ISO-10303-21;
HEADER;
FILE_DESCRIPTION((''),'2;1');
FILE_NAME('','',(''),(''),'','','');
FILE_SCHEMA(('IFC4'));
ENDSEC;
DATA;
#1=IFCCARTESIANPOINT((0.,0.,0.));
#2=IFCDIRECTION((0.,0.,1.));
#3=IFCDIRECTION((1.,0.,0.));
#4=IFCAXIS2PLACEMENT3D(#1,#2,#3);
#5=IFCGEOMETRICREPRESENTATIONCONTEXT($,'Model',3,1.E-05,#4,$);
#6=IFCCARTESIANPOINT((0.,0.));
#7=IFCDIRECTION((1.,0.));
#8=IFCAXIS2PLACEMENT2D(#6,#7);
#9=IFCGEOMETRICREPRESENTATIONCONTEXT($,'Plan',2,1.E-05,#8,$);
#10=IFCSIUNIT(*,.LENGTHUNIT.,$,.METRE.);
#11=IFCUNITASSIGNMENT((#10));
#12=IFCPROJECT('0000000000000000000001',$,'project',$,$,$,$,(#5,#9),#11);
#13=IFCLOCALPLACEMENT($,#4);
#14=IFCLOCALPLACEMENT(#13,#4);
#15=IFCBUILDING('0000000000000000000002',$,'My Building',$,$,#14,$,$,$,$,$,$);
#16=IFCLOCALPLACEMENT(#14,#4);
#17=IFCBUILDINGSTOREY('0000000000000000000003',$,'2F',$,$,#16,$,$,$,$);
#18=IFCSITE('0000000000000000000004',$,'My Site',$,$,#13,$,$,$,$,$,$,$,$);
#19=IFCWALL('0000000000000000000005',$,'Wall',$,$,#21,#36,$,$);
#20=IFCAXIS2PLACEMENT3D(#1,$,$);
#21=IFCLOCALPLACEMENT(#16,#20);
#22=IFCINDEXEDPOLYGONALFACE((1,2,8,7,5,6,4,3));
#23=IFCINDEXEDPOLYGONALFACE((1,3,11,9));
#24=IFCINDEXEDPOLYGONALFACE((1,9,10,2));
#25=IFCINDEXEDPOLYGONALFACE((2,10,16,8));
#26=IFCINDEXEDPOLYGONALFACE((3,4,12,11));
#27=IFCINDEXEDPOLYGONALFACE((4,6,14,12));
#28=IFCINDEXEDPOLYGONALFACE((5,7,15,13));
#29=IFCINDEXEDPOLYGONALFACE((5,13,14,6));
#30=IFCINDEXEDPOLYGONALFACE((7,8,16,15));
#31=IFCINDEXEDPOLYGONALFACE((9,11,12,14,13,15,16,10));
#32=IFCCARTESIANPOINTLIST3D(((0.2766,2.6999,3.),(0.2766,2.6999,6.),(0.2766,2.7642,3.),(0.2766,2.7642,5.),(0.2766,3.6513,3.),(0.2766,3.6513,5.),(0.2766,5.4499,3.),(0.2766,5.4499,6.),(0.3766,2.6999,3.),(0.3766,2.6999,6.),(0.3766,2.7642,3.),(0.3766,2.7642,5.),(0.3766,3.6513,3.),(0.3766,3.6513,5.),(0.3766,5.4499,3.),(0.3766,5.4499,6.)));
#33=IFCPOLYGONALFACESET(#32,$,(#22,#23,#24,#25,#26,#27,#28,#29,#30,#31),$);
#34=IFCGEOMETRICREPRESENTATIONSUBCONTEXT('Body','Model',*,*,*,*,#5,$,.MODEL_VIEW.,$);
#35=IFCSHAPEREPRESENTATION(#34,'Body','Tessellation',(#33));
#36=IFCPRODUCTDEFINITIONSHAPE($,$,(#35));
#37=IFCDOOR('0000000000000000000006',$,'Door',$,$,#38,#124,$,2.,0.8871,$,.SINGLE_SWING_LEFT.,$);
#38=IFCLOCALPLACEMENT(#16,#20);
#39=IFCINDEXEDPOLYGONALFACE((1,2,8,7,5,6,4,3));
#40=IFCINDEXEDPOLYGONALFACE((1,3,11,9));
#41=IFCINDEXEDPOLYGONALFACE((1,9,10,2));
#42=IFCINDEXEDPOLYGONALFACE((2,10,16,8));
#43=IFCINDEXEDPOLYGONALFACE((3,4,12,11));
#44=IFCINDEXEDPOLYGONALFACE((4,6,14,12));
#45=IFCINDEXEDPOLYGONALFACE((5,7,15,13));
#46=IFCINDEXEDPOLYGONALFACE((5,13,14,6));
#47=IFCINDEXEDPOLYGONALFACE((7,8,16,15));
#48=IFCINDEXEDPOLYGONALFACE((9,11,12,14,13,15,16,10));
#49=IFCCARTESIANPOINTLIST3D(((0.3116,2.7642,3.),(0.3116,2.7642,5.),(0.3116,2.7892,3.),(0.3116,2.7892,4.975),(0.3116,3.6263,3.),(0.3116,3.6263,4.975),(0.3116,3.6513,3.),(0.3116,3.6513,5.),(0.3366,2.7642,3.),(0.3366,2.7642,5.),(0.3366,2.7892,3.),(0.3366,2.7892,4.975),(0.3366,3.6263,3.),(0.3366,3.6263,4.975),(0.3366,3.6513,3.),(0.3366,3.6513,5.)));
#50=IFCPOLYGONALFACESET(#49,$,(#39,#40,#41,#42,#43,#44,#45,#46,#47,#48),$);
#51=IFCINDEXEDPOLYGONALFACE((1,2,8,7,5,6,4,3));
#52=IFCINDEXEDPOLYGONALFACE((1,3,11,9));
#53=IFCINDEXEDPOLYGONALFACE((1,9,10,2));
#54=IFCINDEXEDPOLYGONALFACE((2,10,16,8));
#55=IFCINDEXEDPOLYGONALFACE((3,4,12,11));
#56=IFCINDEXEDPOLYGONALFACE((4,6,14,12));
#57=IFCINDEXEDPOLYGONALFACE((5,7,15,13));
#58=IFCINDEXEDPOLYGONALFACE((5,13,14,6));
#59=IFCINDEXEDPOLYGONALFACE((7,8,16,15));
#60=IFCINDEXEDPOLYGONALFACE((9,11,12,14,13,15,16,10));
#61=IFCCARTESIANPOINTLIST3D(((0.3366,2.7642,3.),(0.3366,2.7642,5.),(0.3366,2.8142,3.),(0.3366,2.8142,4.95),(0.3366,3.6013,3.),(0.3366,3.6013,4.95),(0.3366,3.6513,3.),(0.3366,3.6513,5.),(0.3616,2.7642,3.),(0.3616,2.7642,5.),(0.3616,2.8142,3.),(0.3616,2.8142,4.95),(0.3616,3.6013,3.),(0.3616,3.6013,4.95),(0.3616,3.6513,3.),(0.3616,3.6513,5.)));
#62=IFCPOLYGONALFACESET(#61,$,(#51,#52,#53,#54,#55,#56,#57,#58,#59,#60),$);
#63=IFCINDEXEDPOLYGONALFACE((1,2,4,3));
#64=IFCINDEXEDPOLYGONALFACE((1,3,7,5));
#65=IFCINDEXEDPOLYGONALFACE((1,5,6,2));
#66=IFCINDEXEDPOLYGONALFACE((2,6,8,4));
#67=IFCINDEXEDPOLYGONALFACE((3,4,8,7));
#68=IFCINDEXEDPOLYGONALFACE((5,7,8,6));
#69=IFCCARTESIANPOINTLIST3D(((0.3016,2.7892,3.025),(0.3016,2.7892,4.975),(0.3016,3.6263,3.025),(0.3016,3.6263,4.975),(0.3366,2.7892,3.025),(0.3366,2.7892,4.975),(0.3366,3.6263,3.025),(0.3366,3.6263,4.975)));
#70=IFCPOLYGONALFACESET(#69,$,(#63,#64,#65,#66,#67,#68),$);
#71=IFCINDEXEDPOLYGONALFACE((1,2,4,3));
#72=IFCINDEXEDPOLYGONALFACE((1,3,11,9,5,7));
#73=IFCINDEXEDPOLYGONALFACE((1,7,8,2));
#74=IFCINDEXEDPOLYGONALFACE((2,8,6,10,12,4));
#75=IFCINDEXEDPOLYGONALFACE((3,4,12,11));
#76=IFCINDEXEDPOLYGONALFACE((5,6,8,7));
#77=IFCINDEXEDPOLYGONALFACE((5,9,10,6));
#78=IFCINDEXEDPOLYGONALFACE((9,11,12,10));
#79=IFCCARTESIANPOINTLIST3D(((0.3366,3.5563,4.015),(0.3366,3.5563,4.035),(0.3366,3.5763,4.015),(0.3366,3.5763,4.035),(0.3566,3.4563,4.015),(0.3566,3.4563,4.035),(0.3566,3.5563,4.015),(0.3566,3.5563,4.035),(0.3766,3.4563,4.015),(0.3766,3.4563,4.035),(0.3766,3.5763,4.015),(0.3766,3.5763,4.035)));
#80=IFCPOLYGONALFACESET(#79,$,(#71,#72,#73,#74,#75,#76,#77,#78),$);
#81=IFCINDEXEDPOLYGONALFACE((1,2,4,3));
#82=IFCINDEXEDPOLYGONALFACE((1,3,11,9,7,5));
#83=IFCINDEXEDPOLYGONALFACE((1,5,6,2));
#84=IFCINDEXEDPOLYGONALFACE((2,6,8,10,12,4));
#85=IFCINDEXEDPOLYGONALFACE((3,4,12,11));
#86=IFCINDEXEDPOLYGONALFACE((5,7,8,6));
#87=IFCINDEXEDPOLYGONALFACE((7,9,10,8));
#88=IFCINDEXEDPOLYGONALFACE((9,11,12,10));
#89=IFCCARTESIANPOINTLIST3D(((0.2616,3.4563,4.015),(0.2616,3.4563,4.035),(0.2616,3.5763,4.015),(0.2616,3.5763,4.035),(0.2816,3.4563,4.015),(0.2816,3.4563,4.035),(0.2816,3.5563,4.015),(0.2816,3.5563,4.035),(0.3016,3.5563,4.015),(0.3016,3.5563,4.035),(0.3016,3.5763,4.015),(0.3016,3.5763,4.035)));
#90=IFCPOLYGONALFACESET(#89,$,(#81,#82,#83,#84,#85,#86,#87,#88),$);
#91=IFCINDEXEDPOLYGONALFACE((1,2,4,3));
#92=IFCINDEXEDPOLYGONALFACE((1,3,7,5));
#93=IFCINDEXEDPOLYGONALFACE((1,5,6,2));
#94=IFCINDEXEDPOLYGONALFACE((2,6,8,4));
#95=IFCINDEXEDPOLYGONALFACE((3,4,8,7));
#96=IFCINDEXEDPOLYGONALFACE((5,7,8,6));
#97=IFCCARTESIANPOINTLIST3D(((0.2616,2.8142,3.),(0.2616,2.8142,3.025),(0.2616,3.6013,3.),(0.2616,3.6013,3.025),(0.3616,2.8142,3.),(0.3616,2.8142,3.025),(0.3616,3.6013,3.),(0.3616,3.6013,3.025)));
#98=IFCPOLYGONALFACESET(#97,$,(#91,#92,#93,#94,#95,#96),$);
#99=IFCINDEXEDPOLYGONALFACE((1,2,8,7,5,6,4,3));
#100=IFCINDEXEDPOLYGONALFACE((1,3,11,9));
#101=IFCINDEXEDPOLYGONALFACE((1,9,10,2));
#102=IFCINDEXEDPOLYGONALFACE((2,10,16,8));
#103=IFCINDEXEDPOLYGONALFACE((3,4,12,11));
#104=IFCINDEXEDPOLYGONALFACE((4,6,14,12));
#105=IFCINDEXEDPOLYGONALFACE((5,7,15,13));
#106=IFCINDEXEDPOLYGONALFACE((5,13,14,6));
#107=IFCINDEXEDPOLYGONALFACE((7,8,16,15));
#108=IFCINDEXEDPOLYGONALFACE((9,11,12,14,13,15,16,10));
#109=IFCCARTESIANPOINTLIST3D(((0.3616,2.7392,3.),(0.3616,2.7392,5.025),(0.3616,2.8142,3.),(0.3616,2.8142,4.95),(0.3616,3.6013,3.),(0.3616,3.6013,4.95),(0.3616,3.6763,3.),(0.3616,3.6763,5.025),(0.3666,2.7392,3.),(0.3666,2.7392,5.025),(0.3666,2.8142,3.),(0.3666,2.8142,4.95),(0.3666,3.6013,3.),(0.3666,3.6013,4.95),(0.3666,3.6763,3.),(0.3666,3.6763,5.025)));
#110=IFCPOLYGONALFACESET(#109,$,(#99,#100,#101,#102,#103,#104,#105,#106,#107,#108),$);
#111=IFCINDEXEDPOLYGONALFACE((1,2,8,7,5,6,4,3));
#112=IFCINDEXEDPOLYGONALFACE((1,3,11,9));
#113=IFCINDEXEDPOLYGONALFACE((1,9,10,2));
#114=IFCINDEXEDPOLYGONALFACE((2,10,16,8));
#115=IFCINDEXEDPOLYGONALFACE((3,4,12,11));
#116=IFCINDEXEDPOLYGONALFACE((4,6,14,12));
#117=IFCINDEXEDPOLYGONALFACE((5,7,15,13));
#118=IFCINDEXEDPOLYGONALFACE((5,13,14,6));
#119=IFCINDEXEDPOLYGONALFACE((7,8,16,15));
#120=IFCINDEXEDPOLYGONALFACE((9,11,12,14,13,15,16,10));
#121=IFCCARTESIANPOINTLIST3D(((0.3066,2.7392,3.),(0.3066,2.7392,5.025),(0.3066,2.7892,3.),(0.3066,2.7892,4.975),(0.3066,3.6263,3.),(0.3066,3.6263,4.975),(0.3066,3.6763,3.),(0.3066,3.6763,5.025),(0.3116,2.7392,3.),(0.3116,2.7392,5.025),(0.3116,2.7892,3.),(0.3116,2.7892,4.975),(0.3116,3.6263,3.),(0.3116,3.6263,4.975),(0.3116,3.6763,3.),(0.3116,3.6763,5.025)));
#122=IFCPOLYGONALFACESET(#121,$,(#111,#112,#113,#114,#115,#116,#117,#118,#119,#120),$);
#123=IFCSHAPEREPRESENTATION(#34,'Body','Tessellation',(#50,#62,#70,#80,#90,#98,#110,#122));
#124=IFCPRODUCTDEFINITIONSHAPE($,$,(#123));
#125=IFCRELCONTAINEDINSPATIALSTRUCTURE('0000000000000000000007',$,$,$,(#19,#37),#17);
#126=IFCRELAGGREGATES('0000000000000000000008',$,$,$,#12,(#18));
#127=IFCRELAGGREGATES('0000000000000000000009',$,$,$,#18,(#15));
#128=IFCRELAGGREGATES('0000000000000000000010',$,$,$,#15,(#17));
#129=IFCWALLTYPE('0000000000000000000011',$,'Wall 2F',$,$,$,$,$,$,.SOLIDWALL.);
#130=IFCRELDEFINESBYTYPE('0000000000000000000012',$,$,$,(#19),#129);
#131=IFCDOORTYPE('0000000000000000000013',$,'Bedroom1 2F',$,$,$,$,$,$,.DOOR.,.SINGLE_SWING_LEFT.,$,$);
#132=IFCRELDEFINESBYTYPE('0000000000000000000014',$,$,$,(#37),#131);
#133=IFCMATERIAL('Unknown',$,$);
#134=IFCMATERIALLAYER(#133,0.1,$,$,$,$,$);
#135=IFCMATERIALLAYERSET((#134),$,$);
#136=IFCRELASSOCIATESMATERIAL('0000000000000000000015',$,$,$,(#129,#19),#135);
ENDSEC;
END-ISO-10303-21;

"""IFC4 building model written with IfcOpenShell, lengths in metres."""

from ifc_helpers import new_model, entity, si_unit, frame, origin_with_axes, origin_2d_with_axis, place, context, subcontext, project, spatial, line, indexed_curve, outline, extrude, shape, source, transform, mapped, material, layer, layer_set, layer_usage, type_object, type_shapes, element, fill, save


model = new_model("IFC4")

# Units and contexts
model_context = context("Model", 3, precision=1e-05, world=origin_with_axes())
plan_context = context("Plan", 2, precision=1e-05, world=origin_2d_with_axis())
body_context_1 = subcontext(model_context, "Body", "Model", "MODEL_VIEW")
body_context_2 = subcontext(plan_context, "Body", "Plan", "PLAN_VIEW")
ifc_project = project(units=[si_unit("LENGTHUNIT", "METRE")], contexts=[model_context, plan_context])

# Site, building, storey
site_placement = place(None, origin_with_axes())
site = spatial("IfcSite", under=ifc_project, at=site_placement, Name="My Site")
building_placement = place(site_placement, origin_with_axes())
building = spatial("IfcBuilding", under=site, at=building_placement, Name="My Building")
storey_placement = place(building_placement, origin_with_axes())
storey = spatial("IfcBuildingStorey", under=building, at=storey_placement, Name="2F")

# Shared definitions
ifc_material = material(Name="Unknown")

# Shared definitions
ifc_layer_1 = layer(ifc_material, 0.1)
ifc_layer_set_1 = layer_set([ifc_layer_1])
wall_type = type_object("IfcWallType", Name="Wall 2F", PredefinedType="SOLIDWALL", material=ifc_layer_set_1)

# Wall, opening, door
ifc_layer_usage_1 = layer_usage(ifc_layer_set_1, "AXIS2", "POSITIVE", 0.0)
wall_1_placement = place(storey_placement, frame((0.3766, 2.6999, 3.0), z_axis=(0.0, 0.0, 1.0), x_axis=(0.0, 1.0, 0.0)))
wall_1 = element("IfcWall", 1, at=wall_1_placement, inside=storey, type_object=wall_type, material=ifc_layer_usage_1, Name="Wall", context=body_context_1, shape_type="SweptSolid", body=[
    extrude(outline(indexed_curve([(0.0, 0.0), (0.0, 0.1), (2.75, 0.1), (2.75, 0.0)], segments=[line(1, 2, 3, 4, 1)])), origin_with_axes(), (0.0, 0.0, 1.0), 3.0),
])
shared_shape_1 = source(origin_with_axes(), body_context_1, "Body", "SweptSolid", [
    extrude(outline(indexed_curve([(0.0, 0.0), (0.8871, 0.0), (0.8871, 2.0), (0.0, 2.0)], segments=[line(1, 2, 3, 4, 1)])), frame((0.0, -0.6, 0.0), z_axis=(0.0, -1.0, 0.0), x_axis=(1.0, 0.0, 0.0)), (0.0, 0.0, -1.0), 1.2),
])
opening_1_placement = place(wall_1_placement, frame((0.0644, 0.015, 0.0), z_axis=(0.0, 0.0, 1.0), x_axis=(1.0, 0.0, 0.0)))
opening_1 = element("IfcOpeningElement", 2, at=opening_1_placement, cuts=wall_1, PredefinedType="OPENING", context=body_context_1, shape_type="MappedRepresentation", body=[
    mapped(shared_shape_1, transform((0.0, 0.0, 0.0), x_axis=(1.0, 0.0, 0.0), y_axis=(0.0, 1.0, 0.0), z_axis=(0.0, 0.0, 1.0), scale=1.0)),
])
door_type_1 = type_object("IfcDoorType", Name="Bedroom1 2F", OperationType="SINGLE_SWING_LEFT", PredefinedType="DOOR")
shared_shape_2 = source(origin_with_axes(), body_context_1, "Body", "SweptSolid", [
    extrude(outline(indexed_curve([(0.0, 0.0), (0.0, 2.0), (0.8871, 2.0), (0.8871, 0.0), (0.8621, 0.0), (0.8621, 1.975), (0.025, 1.975), (0.025, 0.0)], segments=[line(1, 2, 3, 4, 5, 6, 7, 8, 1)])), frame((0.0, 0.025, 0.0), z_axis=(0.0, -1.0, 0.0), x_axis=(1.0, 0.0, 0.0)), (0.0, 0.0, -1.0), 0.025),
    extrude(outline(indexed_curve([(0.0, 0.0), (0.0, 2.0), (0.8871, 2.0), (0.8871, 0.0), (0.8371, 0.0), (0.8371, 1.95), (0.05, 1.95), (0.05, 0.0)], segments=[line(1, 2, 3, 4, 5, 6, 7, 8, 1)])), frame((0.0, 0.0, 0.0), z_axis=(0.0, -1.0, 0.0), x_axis=(1.0, 0.0, 0.0)), (0.0, 0.0, -1.0), 0.025),
    extrude(outline(indexed_curve([(0.0, 0.0), (0.8371, 0.0), (0.8371, 0.035), (0.0, 0.035)], segments=[line(1, 2, 3, 4, 1)])), frame((0.025, 0.025, 0.025), z_axis=(0.0, 0.0, 1.0), x_axis=(1.0, 0.0, 0.0)), (0.0, 0.0, 1.0), 1.95),
    extrude(outline(indexed_curve([(0.0, 0.0), (0.0, -0.04), (-0.12, -0.04), (-0.12, -0.02), (-0.02, -0.02), (-0.02, 0.0)], segments=[line(1, 2, 3, 4, 5, 6, 1)])), frame((0.8121, 0.025, 1.015), z_axis=(0.0, 0.0, 1.0), x_axis=(1.0, 0.0, 0.0)), (0.0, 0.0, 1.0), 0.02),
    extrude(outline(indexed_curve([(0.0, 0.0), (0.0, 0.04), (-0.12, 0.04), (-0.12, 0.02), (-0.02, 0.02), (-0.02, 0.0)], segments=[line(1, 2, 3, 4, 5, 6, 1)])), frame((0.8121, 0.06, 1.015), z_axis=(0.0, 0.0, 1.0), x_axis=(1.0, 0.0, 0.0)), (0.0, 0.0, 1.0), 0.02),
    extrude(outline(indexed_curve([(0.0, 0.0), (0.7871, 0.0), (0.7871, 0.1), (0.0, 0.1)], segments=[line(1, 2, 3, 4, 1)])), frame((0.05, 0.0, 0.0), z_axis=(0.0, 0.0, 1.0), x_axis=(1.0, 0.0, 0.0)), (0.0, 0.0, 1.0), 0.025),
    extrude(outline(indexed_curve([(0.0, 0.0), (0.0, 2.025), (0.9371, 2.025), (0.9371, 0.0), (0.8621, 0.0), (0.8621, 1.95), (0.075, 1.95), (0.075, 0.0)], segments=[line(1, 2, 3, 4, 5, 6, 7, 8, 1)])), frame((-0.025, -0.005, 0.0), z_axis=(0.0, -1.0, 0.0), x_axis=(1.0, 0.0, 0.0)), (0.0, 0.0, -1.0), 0.005),
    extrude(outline(indexed_curve([(0.0, 0.0), (0.0, 2.025), (0.9371, 2.025), (0.9371, 0.0), (0.8871, 0.0), (0.8871, 1.975), (0.05, 1.975), (0.05, 0.0)], segments=[line(1, 2, 3, 4, 5, 6, 7, 8, 1)])), frame((-0.025, 0.05, 0.0), z_axis=(0.0, -1.0, 0.0), x_axis=(1.0, 0.0, 0.0)), (0.0, 0.0, -1.0), 0.005),
])
shared_shape_3 = source(origin_with_axes(), body_context_2, "Body", "Curve2D", [
    entity("IfcIndexedPolyCurve", entity("IfcCartesianPointList2D", [[0.0, 0.0], [0.0, 0.05], [0.025, 0.05], [0.025, 0.025], [0.05, 0.025], [0.05, 0.0]]), [entity("IfcLineIndex", [1, 2, 3, 4, 5, 6, 1])]),
    entity("IfcIndexedPolyCurve", entity("IfcCartesianPointList2D", [[0.8871, 0.0], [0.8871, 0.05], [0.8621, 0.05], [0.8621, 0.025], [0.8371, 0.025], [0.8371, 0.0]]), [entity("IfcLineIndex", [1, 2, 3, 4, 5, 6, 1])]),
    entity("IfcTrimmedCurve", entity("IfcEllipse", entity("IfcAxis2Placement2D", entity("IfcCartesianPoint", [0.06, 0.05]), entity("IfcDirection", [1.0, 0.0])), 0.8021, 0.8371), [entity("IfcCartesianPoint", [0.8621, 0.05])], [entity("IfcCartesianPoint", [0.06, 0.8871])], True, "CARTESIAN"),
    entity("IfcIndexedPolyCurve", entity("IfcCartesianPointList2D", [[0.025, 0.05], [0.06, 0.05], [0.06, 0.8871], [0.025, 0.8871]]), [entity("IfcLineIndex", [1, 2, 3, 4, 1])]),
])
type_shapes(door_type_1, [shared_shape_2, shared_shape_3])
door_1_placement = place(opening_1_placement, frame((0.0, 0.0, 0.0), z_axis=(0.0, 0.0, 1.0), x_axis=(1.0, 0.0, 0.0)))
door_1 = element("IfcDoor", 3, at=door_1_placement, inside=storey, type_object=door_type_1, Name="Door", OperationType="SINGLE_SWING_LEFT", OverallHeight=2.0, OverallWidth=0.8871, shapes=[
    shape(body_context_1, "Body", "MappedRepresentation", [mapped(shared_shape_2, transform((0.0, 0.0, 0.0), x_axis=(1.0, 0.0, 0.0), y_axis=(0.0, 1.0, 0.0), z_axis=(0.0, 0.0, 1.0), scale=1.0))]),
    shape(body_context_2, "Body", "MappedRepresentation", [mapped(shared_shape_3, transform((0.0, 0.0, 0.0), x_axis=(1.0, 0.0, 0.0), y_axis=(0.0, 1.0, 0.0), z_axis=(0.0, 0.0, 1.0), scale=1.0))]),
])
fill(opening_1, door_1)

save(model, "model.ifc")
